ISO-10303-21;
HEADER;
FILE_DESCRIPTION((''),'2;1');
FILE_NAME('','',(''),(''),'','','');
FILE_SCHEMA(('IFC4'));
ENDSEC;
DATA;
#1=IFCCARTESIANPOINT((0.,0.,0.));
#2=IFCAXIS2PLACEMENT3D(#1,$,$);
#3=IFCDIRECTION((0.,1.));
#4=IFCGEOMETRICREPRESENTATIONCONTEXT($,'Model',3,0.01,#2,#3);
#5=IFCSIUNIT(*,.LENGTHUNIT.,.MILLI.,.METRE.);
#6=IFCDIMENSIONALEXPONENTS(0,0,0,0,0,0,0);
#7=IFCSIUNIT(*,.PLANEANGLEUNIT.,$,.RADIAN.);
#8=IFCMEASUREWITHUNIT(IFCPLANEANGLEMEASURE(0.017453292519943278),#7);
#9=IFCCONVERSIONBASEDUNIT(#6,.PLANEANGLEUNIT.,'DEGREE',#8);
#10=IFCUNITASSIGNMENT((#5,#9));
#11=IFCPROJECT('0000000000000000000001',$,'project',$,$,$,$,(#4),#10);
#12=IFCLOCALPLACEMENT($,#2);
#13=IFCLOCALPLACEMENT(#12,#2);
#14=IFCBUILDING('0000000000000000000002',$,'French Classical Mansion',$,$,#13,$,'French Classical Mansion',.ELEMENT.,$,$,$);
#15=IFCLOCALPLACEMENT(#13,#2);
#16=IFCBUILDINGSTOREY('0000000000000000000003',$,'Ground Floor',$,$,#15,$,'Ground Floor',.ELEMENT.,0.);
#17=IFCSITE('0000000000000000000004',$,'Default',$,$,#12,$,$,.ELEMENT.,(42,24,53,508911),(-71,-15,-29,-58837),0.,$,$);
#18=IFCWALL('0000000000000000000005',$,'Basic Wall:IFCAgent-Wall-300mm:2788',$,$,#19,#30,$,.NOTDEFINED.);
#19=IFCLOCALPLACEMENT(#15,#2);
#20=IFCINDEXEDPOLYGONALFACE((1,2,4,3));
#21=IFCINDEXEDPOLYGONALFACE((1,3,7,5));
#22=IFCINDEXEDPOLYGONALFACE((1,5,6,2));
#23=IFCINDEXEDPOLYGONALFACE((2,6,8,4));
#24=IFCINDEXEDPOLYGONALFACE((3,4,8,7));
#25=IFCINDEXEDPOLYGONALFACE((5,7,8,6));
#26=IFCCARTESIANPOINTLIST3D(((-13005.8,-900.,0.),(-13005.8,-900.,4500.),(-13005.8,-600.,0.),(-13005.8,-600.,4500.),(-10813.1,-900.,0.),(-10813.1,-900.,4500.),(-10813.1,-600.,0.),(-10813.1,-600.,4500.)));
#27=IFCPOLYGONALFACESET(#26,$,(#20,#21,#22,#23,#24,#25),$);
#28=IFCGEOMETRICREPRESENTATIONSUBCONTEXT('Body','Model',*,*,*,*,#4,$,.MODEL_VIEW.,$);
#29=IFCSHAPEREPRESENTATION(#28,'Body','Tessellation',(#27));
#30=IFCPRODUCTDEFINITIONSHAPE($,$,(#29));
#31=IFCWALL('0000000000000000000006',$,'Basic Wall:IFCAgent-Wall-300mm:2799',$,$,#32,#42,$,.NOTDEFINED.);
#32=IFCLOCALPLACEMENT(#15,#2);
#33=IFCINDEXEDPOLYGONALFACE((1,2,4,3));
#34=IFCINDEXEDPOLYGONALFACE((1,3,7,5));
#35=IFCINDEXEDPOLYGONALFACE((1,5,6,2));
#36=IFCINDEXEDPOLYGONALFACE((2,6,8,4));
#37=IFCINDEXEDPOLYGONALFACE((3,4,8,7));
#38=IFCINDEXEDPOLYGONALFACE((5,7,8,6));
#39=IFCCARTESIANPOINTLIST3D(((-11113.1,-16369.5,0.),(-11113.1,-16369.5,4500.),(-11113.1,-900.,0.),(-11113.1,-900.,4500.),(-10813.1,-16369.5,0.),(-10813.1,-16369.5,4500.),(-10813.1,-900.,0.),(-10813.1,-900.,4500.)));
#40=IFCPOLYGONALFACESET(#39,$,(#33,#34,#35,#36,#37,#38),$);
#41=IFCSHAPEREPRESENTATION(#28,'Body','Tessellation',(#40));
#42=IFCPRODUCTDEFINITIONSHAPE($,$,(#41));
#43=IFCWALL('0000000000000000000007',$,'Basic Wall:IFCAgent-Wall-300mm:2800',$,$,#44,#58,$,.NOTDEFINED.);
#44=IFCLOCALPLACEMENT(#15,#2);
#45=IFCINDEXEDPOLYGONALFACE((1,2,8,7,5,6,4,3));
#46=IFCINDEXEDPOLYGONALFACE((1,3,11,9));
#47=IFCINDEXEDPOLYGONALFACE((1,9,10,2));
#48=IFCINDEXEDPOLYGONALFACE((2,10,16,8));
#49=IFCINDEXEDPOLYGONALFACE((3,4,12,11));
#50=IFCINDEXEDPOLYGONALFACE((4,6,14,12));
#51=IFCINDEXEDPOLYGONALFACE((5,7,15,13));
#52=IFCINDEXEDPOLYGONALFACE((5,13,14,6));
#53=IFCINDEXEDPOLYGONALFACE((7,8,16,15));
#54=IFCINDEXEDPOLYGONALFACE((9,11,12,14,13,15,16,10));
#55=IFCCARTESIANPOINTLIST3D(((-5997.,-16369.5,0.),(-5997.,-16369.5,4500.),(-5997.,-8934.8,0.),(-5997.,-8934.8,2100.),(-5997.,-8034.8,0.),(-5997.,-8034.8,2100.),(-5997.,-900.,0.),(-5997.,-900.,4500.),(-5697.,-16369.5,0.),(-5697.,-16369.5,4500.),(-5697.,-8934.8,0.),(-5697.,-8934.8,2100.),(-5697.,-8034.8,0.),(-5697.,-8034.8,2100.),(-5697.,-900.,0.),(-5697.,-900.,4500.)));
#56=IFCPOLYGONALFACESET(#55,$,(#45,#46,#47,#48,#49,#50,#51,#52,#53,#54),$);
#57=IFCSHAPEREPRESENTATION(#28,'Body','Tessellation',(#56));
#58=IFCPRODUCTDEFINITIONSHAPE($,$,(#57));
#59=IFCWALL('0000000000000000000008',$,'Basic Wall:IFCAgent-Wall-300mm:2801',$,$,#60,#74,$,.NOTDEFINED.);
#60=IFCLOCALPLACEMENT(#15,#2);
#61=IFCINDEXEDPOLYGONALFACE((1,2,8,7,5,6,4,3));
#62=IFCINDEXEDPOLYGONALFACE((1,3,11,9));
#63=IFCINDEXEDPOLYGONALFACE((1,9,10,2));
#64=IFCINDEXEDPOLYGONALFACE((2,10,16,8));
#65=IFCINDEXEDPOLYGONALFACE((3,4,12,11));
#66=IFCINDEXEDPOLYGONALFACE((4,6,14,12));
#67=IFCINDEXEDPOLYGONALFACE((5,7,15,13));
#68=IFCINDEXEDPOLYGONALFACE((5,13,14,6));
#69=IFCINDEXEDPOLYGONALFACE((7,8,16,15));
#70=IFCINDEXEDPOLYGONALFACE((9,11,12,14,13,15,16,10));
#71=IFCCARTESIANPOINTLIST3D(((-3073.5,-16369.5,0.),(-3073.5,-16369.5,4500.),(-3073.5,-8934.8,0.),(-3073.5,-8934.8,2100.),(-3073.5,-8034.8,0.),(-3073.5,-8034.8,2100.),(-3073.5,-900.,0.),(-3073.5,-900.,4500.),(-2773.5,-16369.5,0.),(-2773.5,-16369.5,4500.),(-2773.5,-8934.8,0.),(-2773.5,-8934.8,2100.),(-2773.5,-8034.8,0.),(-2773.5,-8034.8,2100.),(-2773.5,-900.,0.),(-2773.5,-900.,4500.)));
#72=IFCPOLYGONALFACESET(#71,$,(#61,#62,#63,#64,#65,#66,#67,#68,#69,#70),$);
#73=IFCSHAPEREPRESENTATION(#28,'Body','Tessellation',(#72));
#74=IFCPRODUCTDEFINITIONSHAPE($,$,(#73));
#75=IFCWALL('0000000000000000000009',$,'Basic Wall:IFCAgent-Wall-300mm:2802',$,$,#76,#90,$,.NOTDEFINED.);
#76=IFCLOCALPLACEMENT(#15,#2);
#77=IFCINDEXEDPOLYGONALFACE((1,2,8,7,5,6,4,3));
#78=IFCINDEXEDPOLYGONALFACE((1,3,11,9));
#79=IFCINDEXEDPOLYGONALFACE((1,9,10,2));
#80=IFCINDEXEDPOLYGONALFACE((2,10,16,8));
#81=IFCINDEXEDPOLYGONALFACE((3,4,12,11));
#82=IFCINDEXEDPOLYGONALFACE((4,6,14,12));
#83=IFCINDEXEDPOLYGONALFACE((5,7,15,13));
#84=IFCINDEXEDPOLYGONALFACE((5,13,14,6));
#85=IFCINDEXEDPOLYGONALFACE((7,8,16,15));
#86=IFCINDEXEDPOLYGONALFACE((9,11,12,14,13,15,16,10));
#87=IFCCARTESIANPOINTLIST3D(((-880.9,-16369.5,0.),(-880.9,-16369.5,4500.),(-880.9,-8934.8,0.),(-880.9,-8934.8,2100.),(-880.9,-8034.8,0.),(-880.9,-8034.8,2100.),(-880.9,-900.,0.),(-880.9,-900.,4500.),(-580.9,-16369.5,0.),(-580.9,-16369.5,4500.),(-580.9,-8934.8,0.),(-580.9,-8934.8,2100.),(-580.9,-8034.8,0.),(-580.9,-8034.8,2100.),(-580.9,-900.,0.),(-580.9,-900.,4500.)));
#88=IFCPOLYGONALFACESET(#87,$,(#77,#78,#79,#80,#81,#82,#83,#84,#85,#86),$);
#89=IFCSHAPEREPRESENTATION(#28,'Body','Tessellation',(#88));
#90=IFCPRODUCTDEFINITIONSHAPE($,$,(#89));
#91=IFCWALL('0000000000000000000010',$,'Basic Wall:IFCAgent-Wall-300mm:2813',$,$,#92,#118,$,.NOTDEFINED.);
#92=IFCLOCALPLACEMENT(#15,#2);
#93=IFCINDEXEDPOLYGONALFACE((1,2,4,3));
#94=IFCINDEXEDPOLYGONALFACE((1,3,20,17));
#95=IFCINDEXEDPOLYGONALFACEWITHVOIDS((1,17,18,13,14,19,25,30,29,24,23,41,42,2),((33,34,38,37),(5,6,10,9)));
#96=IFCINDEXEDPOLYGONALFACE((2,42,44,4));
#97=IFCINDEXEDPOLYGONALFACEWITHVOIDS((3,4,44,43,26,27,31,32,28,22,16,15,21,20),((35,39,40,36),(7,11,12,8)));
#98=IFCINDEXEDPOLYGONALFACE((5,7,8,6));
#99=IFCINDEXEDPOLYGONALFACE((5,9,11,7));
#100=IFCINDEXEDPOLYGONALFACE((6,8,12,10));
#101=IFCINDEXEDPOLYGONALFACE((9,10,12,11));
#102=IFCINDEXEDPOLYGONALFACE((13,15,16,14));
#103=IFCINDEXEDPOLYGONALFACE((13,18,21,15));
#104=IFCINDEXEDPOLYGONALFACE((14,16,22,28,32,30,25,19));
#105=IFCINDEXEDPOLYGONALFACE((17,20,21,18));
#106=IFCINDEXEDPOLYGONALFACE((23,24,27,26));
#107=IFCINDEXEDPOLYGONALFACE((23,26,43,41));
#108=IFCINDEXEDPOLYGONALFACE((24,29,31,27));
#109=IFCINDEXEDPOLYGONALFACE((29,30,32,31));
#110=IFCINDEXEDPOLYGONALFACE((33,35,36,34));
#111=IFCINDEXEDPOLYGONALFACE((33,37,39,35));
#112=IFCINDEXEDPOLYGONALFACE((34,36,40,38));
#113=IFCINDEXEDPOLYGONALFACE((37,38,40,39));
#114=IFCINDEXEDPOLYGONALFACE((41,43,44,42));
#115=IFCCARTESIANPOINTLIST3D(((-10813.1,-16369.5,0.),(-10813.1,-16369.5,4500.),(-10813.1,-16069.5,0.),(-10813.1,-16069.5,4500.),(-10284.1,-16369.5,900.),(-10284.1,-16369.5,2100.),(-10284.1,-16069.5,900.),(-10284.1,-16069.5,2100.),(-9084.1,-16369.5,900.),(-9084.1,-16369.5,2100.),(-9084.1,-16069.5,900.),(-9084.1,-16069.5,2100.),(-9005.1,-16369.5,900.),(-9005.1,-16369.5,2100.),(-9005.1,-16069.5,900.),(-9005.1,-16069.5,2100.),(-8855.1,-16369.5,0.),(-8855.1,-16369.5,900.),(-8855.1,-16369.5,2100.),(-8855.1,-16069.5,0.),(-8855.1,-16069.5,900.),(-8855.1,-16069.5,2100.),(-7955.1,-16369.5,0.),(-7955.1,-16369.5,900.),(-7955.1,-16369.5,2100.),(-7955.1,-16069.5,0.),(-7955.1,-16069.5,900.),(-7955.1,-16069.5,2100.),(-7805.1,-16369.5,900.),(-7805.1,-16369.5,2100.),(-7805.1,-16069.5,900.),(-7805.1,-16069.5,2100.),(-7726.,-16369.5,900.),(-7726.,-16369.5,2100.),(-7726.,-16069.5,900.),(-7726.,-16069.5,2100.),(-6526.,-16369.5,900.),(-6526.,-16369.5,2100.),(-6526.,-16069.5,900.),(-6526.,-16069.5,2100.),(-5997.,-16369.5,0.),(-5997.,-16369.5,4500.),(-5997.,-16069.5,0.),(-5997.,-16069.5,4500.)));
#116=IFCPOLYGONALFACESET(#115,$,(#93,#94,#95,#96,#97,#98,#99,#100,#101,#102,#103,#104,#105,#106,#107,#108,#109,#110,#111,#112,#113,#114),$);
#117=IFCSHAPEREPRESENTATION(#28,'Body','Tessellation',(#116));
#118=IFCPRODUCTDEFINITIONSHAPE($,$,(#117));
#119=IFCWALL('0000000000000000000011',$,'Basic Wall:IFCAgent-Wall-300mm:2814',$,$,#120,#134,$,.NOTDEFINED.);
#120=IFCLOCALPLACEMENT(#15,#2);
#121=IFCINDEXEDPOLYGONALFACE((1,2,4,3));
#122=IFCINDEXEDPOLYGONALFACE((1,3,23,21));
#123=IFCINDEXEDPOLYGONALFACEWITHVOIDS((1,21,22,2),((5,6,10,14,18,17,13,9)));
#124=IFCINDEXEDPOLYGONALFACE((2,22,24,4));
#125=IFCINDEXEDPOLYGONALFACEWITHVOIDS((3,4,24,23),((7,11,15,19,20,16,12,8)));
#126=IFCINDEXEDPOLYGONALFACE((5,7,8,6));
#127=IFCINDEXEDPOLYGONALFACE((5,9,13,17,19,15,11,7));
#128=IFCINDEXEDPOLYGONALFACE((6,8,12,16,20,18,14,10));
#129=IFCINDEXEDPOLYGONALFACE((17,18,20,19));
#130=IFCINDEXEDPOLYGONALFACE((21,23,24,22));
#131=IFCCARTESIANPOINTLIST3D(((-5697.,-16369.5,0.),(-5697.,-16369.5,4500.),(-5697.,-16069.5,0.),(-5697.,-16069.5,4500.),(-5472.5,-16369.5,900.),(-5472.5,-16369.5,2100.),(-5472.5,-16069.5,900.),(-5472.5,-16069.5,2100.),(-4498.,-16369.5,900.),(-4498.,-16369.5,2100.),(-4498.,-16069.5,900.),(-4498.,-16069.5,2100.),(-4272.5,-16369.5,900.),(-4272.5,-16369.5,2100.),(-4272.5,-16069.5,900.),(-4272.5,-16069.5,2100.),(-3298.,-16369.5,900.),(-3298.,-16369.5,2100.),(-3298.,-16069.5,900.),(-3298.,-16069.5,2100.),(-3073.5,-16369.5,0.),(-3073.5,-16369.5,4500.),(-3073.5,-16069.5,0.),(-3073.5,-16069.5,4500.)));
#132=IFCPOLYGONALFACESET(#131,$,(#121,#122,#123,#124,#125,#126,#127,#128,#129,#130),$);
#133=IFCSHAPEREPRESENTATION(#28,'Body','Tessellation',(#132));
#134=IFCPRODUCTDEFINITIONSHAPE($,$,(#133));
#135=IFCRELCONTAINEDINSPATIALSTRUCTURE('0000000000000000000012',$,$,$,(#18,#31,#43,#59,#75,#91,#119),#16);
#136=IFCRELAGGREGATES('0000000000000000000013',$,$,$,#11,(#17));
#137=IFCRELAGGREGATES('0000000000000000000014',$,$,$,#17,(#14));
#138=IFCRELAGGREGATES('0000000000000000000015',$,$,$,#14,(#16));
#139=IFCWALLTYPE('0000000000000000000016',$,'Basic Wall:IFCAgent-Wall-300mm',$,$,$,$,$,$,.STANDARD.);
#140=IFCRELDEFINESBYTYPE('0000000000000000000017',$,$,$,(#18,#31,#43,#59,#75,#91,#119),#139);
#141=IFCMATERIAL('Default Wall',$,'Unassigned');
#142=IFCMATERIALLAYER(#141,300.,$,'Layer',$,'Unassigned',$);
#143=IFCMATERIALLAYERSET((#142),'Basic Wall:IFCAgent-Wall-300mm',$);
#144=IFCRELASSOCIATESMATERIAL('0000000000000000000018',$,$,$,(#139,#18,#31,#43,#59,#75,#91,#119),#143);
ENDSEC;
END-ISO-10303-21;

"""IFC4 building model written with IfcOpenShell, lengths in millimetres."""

from ifc_helpers import new_model, entity, si_unit, converted_unit, direction, frame, frame_2d, origin, place, context, subcontext, project, spatial, rectangle, extrude, material, layer, layer_set, layer_usage, type_object, element, save


model = new_model("IFC4")

# Units and contexts
model_context = context("Model", 3, precision=0.01, world=origin(), true_north=direction((0.0, 1.0)))
body_context = subcontext(model_context, "Body", "Model", "MODEL_VIEW")
ifc_project = project(units=[si_unit("LENGTHUNIT", "METRE", prefix="MILLI"), converted_unit("PLANEANGLEUNIT", "DEGREE", entity("IfcPlaneAngleMeasure", 0.017453292519943278), si_unit("PLANEANGLEUNIT", "RADIAN"), dimensions=[0, 0, 0, 0, 0, 0, 0])], contexts=[model_context])

# Site, building, storey
site_placement = place(None, origin())
site = spatial("IfcSite", under=ifc_project, at=site_placement, Name="Default", CompositionType="ELEMENT", RefLatitude=(42, 24, 53, 508911), RefLongitude=(-71, -15, -29, -58837), RefElevation=0.0)
building_placement = place(site_placement, origin())
building = spatial("IfcBuilding", under=site, at=building_placement, Name="French Classical Mansion", LongName="French Classical Mansion", CompositionType="ELEMENT")
storey_placement = place(building_placement, origin())
storey = spatial("IfcBuildingStorey", under=building, at=storey_placement, Name="Ground Floor", LongName="Ground Floor", CompositionType="ELEMENT", Elevation=0.0)

# Walls
ifc_material = material(Name="Default Wall", Category="Unassigned")
ifc_layer = layer(ifc_material, 300.0, Name="Layer", Category="Unassigned")
ifc_layer_set = layer_set([ifc_layer], Name="Basic Wall:IFCAgent-Wall-300mm")
ifc_layer_usage_1 = layer_usage(ifc_layer_set, "AXIS2", "NEGATIVE", 150.0)
wall_type = type_object("IfcWallType", Name="Basic Wall:IFCAgent-Wall-300mm", PredefinedType="STANDARD", material=ifc_layer_set)
wall_1_placement = place(storey_placement, frame((-13005.8, -750.0, 0.0)))
element("IfcWall", 1, at=wall_1_placement, inside=storey, type_object=wall_type, material=ifc_layer_usage_1, Name="Basic Wall:IFCAgent-Wall-300mm:2788", PredefinedType="NOTDEFINED", context=body_context, shape_type="SweptSolid", body=[
    extrude(rectangle(XDim=2192.6, YDim=300.0, at=frame_2d((1096.3, 0.0), x_axis=(-1.0, 0.0))), origin(), (0.0, 0.0, 1.0), 4500.0),
])
ifc_layer_usage_2 = layer_usage(ifc_layer_set, "AXIS2", "NEGATIVE", 150.0)
wall_2_placement = place(storey_placement, frame((-10963.1, -16369.5, 0.0), z_axis=(0.0, 0.0, 1.0), x_axis=(0.0, 1.0, 0.0)))
element("IfcWall", 2, at=wall_2_placement, inside=storey, type_object=wall_type, material=ifc_layer_usage_2, Name="Basic Wall:IFCAgent-Wall-300mm:2799", PredefinedType="NOTDEFINED", context=body_context, shape_type="SweptSolid", body=[
    extrude(rectangle(XDim=15469.5, YDim=300.0, at=frame_2d((7734.8, 0.0), x_axis=(-1.0, 0.0))), origin(), (0.0, 0.0, 1.0), 4500.0),
])

# Walls, openings
ifc_layer_usage_3 = layer_usage(ifc_layer_set, "AXIS2", "NEGATIVE", 150.0)
wall_3_placement = place(storey_placement, frame((-5847.0, -16369.5, 0.0), z_axis=(0.0, 0.0, 1.0), x_axis=(0.0, 1.0, 0.0)))
wall_3 = element("IfcWall", 3, at=wall_3_placement, inside=storey, type_object=wall_type, material=ifc_layer_usage_3, Name="Basic Wall:IFCAgent-Wall-300mm:2800", PredefinedType="NOTDEFINED", context=body_context, shape_type="SweptSolid", body=[
    extrude(rectangle(XDim=15469.5, YDim=300.0, at=frame_2d((7734.8, 0.0), x_axis=(1.0, 0.0))), origin(), (0.0, 0.0, 1.0), 4500.0),
])
opening_1_placement = place(wall_3_placement, origin())
element("IfcOpeningElement", 4, at=opening_1_placement, cuts=wall_3, PredefinedType="OPENING", context=body_context, shape_type="SweptSolid", body=[
    extrude(rectangle(XDim=2100.0, YDim=900.0, at=frame_2d((0.0, 0.0), x_axis=(1.0, 0.0))), frame((7884.7, -150.0, 1050.0), z_axis=(0.0, 1.0, 0.0), x_axis=(0.0, 0.0, -1.0)), (0.0, 0.0, 1.0), 300.0),
])
ifc_layer_usage_4 = layer_usage(ifc_layer_set, "AXIS2", "NEGATIVE", 150.0)
wall_4_placement = place(storey_placement, frame((-2923.5, -16369.5, 0.0), z_axis=(0.0, 0.0, 1.0), x_axis=(0.0, 1.0, 0.0)))
wall_4 = element("IfcWall", 5, at=wall_4_placement, inside=storey, type_object=wall_type, material=ifc_layer_usage_4, Name="Basic Wall:IFCAgent-Wall-300mm:2801", PredefinedType="NOTDEFINED", context=body_context, shape_type="SweptSolid", body=[
    extrude(rectangle(XDim=15469.5, YDim=300.0, at=frame_2d((7734.8, 0.0), x_axis=(-1.0, 0.0))), origin(), (0.0, 0.0, 1.0), 4500.0),
])
opening_2_placement = place(wall_4_placement, origin())
element("IfcOpeningElement", 6, at=opening_2_placement, cuts=wall_4, PredefinedType="OPENING", context=body_context, shape_type="SweptSolid", body=[
    extrude(rectangle(XDim=2100.0, YDim=900.0, at=frame_2d((0.0, 0.0), x_axis=(1.0, 0.0))), frame((7884.7, -150.0, 1050.0), z_axis=(0.0, 1.0, 0.0), x_axis=(0.0, 0.0, -1.0)), (0.0, 0.0, 1.0), 300.0),
])
ifc_layer_usage_5 = layer_usage(ifc_layer_set, "AXIS2", "NEGATIVE", 150.0)
wall_5_placement = place(storey_placement, frame((-730.9, -16369.5, 0.0), z_axis=(0.0, 0.0, 1.0), x_axis=(0.0, 1.0, 0.0)))
wall_5 = element("IfcWall", 7, at=wall_5_placement, inside=storey, type_object=wall_type, material=ifc_layer_usage_5, Name="Basic Wall:IFCAgent-Wall-300mm:2802", PredefinedType="NOTDEFINED", context=body_context, shape_type="SweptSolid", body=[
    extrude(rectangle(XDim=15469.5, YDim=300.0, at=frame_2d((7734.8, 0.0), x_axis=(1.0, 0.0))), origin(), (0.0, 0.0, 1.0), 4500.0),
])
opening_3_placement = place(wall_5_placement, origin())
element("IfcOpeningElement", 8, at=opening_3_placement, cuts=wall_5, PredefinedType="OPENING", context=body_context, shape_type="SweptSolid", body=[
    extrude(rectangle(XDim=2100.0, YDim=900.0, at=frame_2d((0.0, 0.0), x_axis=(1.0, 0.0))), frame((7884.7, -150.0, 1050.0), z_axis=(0.0, 1.0, 0.0), x_axis=(0.0, 0.0, -1.0)), (0.0, 0.0, 1.0), 300.0),
])

# Walls, openings
ifc_layer_usage_6 = layer_usage(ifc_layer_set, "AXIS2", "NEGATIVE", 150.0)
wall_6_placement = place(storey_placement, frame((-10813.1, -16219.5, 0.0)))
wall_6 = element("IfcWall", 9, at=wall_6_placement, inside=storey, type_object=wall_type, material=ifc_layer_usage_6, Name="Basic Wall:IFCAgent-Wall-300mm:2813", PredefinedType="NOTDEFINED", context=body_context, shape_type="SweptSolid", body=[
    extrude(rectangle(XDim=4816.1, YDim=300.0, at=frame_2d((2408.1, 0.0), x_axis=(-1.0, 0.0))), origin(), (0.0, 0.0, 1.0), 4500.0),
])
opening_4_placement = place(wall_6_placement, origin())
element("IfcOpeningElement", 10, at=opening_4_placement, cuts=wall_6, PredefinedType="OPENING", context=body_context, shape_type="SweptSolid", body=[
    extrude(rectangle(XDim=2100.0, YDim=900.0, at=frame_2d((0.0, 0.0), x_axis=(1.0, 0.0))), frame((2408.1, -150.0, 1050.0), z_axis=(0.0, 1.0, 0.0), x_axis=(0.0, 0.0, -1.0)), (0.0, 0.0, 1.0), 300.0),
])
opening_5_placement = place(wall_6_placement, origin())
element("IfcOpeningElement", 11, at=opening_5_placement, cuts=wall_6, PredefinedType="OPENING", context=body_context, shape_type="SweptSolid", body=[
    extrude(rectangle(XDim=2100.0, YDim=900.0, at=frame_2d((0.0, 0.0), x_axis=(1.0, 0.0))), frame((2408.1, -150.0, 1050.0), z_axis=(0.0, 1.0, 0.0), x_axis=(0.0, 0.0, -1.0)), (0.0, 0.0, 1.0), 300.0),
])
opening_6_placement = place(wall_6_placement, origin())
element("IfcOpeningElement", 12, at=opening_6_placement, cuts=wall_6, PredefinedType="OPENING", context=body_context, shape_type="SweptSolid", body=[
    extrude(rectangle(XDim=1200.0, YDim=1200.0, at=frame_2d((0.0, 0.0), x_axis=(1.0, 0.0))), frame((1129.0, -150.0, 1500.0), z_axis=(0.0, 1.0, 0.0), x_axis=(0.0, 0.0, -1.0)), (0.0, 0.0, 1.0), 300.0),
])
opening_7_placement = place(wall_6_placement, origin())
element("IfcOpeningElement", 13, at=opening_7_placement, cuts=wall_6, PredefinedType="OPENING", context=body_context, shape_type="SweptSolid", body=[
    extrude(rectangle(XDim=1200.0, YDim=1200.0, at=frame_2d((0.0, 0.0), x_axis=(1.0, 0.0))), frame((2408.1, -150.0, 1500.0), z_axis=(0.0, 1.0, 0.0), x_axis=(0.0, 0.0, -1.0)), (0.0, 0.0, 1.0), 300.0),
])
opening_8_placement = place(wall_6_placement, origin())
element("IfcOpeningElement", 14, at=opening_8_placement, cuts=wall_6, PredefinedType="OPENING", context=body_context, shape_type="SweptSolid", body=[
    extrude(rectangle(XDim=1200.0, YDim=1200.0, at=frame_2d((0.0, 0.0), x_axis=(1.0, 0.0))), frame((3687.1, -150.0, 1500.0), z_axis=(0.0, 1.0, 0.0), x_axis=(0.0, 0.0, -1.0)), (0.0, 0.0, 1.0), 300.0),
])
ifc_layer_usage_7 = layer_usage(ifc_layer_set, "AXIS2", "NEGATIVE", 150.0)
wall_7_placement = place(storey_placement, frame((-5697.0, -16219.5, 0.0)))
wall_7 = element("IfcWall", 15, at=wall_7_placement, inside=storey, type_object=wall_type, material=ifc_layer_usage_7, Name="Basic Wall:IFCAgent-Wall-300mm:2814", PredefinedType="NOTDEFINED", context=body_context, shape_type="SweptSolid", body=[
    extrude(rectangle(XDim=2623.5, YDim=300.0, at=frame_2d((1311.7, 0.0), x_axis=(-1.0, 0.0))), origin(), (0.0, 0.0, 1.0), 4500.0),
])
opening_9_placement = place(wall_7_placement, origin())
element("IfcOpeningElement", 16, at=opening_9_placement, cuts=wall_7, PredefinedType="OPENING", context=body_context, shape_type="SweptSolid", body=[
    extrude(rectangle(XDim=1200.0, YDim=1200.0, at=frame_2d((0.0, 0.0), x_axis=(1.0, 0.0))), frame((824.5, -150.0, 1500.0), z_axis=(0.0, 1.0, 0.0), x_axis=(0.0, 0.0, -1.0)), (0.0, 0.0, 1.0), 300.0),
])
opening_10_placement = place(wall_7_placement, origin())
element("IfcOpeningElement", 17, at=opening_10_placement, cuts=wall_7, PredefinedType="OPENING", context=body_context, shape_type="SweptSolid", body=[
    extrude(rectangle(XDim=1200.0, YDim=1200.0, at=frame_2d((0.0, 0.0), x_axis=(1.0, 0.0))), frame((1799.0, -150.0, 1500.0), z_axis=(0.0, 1.0, 0.0), x_axis=(0.0, 0.0, -1.0)), (0.0, 0.0, 1.0), 300.0),
])

save(model, "model.ifc")
